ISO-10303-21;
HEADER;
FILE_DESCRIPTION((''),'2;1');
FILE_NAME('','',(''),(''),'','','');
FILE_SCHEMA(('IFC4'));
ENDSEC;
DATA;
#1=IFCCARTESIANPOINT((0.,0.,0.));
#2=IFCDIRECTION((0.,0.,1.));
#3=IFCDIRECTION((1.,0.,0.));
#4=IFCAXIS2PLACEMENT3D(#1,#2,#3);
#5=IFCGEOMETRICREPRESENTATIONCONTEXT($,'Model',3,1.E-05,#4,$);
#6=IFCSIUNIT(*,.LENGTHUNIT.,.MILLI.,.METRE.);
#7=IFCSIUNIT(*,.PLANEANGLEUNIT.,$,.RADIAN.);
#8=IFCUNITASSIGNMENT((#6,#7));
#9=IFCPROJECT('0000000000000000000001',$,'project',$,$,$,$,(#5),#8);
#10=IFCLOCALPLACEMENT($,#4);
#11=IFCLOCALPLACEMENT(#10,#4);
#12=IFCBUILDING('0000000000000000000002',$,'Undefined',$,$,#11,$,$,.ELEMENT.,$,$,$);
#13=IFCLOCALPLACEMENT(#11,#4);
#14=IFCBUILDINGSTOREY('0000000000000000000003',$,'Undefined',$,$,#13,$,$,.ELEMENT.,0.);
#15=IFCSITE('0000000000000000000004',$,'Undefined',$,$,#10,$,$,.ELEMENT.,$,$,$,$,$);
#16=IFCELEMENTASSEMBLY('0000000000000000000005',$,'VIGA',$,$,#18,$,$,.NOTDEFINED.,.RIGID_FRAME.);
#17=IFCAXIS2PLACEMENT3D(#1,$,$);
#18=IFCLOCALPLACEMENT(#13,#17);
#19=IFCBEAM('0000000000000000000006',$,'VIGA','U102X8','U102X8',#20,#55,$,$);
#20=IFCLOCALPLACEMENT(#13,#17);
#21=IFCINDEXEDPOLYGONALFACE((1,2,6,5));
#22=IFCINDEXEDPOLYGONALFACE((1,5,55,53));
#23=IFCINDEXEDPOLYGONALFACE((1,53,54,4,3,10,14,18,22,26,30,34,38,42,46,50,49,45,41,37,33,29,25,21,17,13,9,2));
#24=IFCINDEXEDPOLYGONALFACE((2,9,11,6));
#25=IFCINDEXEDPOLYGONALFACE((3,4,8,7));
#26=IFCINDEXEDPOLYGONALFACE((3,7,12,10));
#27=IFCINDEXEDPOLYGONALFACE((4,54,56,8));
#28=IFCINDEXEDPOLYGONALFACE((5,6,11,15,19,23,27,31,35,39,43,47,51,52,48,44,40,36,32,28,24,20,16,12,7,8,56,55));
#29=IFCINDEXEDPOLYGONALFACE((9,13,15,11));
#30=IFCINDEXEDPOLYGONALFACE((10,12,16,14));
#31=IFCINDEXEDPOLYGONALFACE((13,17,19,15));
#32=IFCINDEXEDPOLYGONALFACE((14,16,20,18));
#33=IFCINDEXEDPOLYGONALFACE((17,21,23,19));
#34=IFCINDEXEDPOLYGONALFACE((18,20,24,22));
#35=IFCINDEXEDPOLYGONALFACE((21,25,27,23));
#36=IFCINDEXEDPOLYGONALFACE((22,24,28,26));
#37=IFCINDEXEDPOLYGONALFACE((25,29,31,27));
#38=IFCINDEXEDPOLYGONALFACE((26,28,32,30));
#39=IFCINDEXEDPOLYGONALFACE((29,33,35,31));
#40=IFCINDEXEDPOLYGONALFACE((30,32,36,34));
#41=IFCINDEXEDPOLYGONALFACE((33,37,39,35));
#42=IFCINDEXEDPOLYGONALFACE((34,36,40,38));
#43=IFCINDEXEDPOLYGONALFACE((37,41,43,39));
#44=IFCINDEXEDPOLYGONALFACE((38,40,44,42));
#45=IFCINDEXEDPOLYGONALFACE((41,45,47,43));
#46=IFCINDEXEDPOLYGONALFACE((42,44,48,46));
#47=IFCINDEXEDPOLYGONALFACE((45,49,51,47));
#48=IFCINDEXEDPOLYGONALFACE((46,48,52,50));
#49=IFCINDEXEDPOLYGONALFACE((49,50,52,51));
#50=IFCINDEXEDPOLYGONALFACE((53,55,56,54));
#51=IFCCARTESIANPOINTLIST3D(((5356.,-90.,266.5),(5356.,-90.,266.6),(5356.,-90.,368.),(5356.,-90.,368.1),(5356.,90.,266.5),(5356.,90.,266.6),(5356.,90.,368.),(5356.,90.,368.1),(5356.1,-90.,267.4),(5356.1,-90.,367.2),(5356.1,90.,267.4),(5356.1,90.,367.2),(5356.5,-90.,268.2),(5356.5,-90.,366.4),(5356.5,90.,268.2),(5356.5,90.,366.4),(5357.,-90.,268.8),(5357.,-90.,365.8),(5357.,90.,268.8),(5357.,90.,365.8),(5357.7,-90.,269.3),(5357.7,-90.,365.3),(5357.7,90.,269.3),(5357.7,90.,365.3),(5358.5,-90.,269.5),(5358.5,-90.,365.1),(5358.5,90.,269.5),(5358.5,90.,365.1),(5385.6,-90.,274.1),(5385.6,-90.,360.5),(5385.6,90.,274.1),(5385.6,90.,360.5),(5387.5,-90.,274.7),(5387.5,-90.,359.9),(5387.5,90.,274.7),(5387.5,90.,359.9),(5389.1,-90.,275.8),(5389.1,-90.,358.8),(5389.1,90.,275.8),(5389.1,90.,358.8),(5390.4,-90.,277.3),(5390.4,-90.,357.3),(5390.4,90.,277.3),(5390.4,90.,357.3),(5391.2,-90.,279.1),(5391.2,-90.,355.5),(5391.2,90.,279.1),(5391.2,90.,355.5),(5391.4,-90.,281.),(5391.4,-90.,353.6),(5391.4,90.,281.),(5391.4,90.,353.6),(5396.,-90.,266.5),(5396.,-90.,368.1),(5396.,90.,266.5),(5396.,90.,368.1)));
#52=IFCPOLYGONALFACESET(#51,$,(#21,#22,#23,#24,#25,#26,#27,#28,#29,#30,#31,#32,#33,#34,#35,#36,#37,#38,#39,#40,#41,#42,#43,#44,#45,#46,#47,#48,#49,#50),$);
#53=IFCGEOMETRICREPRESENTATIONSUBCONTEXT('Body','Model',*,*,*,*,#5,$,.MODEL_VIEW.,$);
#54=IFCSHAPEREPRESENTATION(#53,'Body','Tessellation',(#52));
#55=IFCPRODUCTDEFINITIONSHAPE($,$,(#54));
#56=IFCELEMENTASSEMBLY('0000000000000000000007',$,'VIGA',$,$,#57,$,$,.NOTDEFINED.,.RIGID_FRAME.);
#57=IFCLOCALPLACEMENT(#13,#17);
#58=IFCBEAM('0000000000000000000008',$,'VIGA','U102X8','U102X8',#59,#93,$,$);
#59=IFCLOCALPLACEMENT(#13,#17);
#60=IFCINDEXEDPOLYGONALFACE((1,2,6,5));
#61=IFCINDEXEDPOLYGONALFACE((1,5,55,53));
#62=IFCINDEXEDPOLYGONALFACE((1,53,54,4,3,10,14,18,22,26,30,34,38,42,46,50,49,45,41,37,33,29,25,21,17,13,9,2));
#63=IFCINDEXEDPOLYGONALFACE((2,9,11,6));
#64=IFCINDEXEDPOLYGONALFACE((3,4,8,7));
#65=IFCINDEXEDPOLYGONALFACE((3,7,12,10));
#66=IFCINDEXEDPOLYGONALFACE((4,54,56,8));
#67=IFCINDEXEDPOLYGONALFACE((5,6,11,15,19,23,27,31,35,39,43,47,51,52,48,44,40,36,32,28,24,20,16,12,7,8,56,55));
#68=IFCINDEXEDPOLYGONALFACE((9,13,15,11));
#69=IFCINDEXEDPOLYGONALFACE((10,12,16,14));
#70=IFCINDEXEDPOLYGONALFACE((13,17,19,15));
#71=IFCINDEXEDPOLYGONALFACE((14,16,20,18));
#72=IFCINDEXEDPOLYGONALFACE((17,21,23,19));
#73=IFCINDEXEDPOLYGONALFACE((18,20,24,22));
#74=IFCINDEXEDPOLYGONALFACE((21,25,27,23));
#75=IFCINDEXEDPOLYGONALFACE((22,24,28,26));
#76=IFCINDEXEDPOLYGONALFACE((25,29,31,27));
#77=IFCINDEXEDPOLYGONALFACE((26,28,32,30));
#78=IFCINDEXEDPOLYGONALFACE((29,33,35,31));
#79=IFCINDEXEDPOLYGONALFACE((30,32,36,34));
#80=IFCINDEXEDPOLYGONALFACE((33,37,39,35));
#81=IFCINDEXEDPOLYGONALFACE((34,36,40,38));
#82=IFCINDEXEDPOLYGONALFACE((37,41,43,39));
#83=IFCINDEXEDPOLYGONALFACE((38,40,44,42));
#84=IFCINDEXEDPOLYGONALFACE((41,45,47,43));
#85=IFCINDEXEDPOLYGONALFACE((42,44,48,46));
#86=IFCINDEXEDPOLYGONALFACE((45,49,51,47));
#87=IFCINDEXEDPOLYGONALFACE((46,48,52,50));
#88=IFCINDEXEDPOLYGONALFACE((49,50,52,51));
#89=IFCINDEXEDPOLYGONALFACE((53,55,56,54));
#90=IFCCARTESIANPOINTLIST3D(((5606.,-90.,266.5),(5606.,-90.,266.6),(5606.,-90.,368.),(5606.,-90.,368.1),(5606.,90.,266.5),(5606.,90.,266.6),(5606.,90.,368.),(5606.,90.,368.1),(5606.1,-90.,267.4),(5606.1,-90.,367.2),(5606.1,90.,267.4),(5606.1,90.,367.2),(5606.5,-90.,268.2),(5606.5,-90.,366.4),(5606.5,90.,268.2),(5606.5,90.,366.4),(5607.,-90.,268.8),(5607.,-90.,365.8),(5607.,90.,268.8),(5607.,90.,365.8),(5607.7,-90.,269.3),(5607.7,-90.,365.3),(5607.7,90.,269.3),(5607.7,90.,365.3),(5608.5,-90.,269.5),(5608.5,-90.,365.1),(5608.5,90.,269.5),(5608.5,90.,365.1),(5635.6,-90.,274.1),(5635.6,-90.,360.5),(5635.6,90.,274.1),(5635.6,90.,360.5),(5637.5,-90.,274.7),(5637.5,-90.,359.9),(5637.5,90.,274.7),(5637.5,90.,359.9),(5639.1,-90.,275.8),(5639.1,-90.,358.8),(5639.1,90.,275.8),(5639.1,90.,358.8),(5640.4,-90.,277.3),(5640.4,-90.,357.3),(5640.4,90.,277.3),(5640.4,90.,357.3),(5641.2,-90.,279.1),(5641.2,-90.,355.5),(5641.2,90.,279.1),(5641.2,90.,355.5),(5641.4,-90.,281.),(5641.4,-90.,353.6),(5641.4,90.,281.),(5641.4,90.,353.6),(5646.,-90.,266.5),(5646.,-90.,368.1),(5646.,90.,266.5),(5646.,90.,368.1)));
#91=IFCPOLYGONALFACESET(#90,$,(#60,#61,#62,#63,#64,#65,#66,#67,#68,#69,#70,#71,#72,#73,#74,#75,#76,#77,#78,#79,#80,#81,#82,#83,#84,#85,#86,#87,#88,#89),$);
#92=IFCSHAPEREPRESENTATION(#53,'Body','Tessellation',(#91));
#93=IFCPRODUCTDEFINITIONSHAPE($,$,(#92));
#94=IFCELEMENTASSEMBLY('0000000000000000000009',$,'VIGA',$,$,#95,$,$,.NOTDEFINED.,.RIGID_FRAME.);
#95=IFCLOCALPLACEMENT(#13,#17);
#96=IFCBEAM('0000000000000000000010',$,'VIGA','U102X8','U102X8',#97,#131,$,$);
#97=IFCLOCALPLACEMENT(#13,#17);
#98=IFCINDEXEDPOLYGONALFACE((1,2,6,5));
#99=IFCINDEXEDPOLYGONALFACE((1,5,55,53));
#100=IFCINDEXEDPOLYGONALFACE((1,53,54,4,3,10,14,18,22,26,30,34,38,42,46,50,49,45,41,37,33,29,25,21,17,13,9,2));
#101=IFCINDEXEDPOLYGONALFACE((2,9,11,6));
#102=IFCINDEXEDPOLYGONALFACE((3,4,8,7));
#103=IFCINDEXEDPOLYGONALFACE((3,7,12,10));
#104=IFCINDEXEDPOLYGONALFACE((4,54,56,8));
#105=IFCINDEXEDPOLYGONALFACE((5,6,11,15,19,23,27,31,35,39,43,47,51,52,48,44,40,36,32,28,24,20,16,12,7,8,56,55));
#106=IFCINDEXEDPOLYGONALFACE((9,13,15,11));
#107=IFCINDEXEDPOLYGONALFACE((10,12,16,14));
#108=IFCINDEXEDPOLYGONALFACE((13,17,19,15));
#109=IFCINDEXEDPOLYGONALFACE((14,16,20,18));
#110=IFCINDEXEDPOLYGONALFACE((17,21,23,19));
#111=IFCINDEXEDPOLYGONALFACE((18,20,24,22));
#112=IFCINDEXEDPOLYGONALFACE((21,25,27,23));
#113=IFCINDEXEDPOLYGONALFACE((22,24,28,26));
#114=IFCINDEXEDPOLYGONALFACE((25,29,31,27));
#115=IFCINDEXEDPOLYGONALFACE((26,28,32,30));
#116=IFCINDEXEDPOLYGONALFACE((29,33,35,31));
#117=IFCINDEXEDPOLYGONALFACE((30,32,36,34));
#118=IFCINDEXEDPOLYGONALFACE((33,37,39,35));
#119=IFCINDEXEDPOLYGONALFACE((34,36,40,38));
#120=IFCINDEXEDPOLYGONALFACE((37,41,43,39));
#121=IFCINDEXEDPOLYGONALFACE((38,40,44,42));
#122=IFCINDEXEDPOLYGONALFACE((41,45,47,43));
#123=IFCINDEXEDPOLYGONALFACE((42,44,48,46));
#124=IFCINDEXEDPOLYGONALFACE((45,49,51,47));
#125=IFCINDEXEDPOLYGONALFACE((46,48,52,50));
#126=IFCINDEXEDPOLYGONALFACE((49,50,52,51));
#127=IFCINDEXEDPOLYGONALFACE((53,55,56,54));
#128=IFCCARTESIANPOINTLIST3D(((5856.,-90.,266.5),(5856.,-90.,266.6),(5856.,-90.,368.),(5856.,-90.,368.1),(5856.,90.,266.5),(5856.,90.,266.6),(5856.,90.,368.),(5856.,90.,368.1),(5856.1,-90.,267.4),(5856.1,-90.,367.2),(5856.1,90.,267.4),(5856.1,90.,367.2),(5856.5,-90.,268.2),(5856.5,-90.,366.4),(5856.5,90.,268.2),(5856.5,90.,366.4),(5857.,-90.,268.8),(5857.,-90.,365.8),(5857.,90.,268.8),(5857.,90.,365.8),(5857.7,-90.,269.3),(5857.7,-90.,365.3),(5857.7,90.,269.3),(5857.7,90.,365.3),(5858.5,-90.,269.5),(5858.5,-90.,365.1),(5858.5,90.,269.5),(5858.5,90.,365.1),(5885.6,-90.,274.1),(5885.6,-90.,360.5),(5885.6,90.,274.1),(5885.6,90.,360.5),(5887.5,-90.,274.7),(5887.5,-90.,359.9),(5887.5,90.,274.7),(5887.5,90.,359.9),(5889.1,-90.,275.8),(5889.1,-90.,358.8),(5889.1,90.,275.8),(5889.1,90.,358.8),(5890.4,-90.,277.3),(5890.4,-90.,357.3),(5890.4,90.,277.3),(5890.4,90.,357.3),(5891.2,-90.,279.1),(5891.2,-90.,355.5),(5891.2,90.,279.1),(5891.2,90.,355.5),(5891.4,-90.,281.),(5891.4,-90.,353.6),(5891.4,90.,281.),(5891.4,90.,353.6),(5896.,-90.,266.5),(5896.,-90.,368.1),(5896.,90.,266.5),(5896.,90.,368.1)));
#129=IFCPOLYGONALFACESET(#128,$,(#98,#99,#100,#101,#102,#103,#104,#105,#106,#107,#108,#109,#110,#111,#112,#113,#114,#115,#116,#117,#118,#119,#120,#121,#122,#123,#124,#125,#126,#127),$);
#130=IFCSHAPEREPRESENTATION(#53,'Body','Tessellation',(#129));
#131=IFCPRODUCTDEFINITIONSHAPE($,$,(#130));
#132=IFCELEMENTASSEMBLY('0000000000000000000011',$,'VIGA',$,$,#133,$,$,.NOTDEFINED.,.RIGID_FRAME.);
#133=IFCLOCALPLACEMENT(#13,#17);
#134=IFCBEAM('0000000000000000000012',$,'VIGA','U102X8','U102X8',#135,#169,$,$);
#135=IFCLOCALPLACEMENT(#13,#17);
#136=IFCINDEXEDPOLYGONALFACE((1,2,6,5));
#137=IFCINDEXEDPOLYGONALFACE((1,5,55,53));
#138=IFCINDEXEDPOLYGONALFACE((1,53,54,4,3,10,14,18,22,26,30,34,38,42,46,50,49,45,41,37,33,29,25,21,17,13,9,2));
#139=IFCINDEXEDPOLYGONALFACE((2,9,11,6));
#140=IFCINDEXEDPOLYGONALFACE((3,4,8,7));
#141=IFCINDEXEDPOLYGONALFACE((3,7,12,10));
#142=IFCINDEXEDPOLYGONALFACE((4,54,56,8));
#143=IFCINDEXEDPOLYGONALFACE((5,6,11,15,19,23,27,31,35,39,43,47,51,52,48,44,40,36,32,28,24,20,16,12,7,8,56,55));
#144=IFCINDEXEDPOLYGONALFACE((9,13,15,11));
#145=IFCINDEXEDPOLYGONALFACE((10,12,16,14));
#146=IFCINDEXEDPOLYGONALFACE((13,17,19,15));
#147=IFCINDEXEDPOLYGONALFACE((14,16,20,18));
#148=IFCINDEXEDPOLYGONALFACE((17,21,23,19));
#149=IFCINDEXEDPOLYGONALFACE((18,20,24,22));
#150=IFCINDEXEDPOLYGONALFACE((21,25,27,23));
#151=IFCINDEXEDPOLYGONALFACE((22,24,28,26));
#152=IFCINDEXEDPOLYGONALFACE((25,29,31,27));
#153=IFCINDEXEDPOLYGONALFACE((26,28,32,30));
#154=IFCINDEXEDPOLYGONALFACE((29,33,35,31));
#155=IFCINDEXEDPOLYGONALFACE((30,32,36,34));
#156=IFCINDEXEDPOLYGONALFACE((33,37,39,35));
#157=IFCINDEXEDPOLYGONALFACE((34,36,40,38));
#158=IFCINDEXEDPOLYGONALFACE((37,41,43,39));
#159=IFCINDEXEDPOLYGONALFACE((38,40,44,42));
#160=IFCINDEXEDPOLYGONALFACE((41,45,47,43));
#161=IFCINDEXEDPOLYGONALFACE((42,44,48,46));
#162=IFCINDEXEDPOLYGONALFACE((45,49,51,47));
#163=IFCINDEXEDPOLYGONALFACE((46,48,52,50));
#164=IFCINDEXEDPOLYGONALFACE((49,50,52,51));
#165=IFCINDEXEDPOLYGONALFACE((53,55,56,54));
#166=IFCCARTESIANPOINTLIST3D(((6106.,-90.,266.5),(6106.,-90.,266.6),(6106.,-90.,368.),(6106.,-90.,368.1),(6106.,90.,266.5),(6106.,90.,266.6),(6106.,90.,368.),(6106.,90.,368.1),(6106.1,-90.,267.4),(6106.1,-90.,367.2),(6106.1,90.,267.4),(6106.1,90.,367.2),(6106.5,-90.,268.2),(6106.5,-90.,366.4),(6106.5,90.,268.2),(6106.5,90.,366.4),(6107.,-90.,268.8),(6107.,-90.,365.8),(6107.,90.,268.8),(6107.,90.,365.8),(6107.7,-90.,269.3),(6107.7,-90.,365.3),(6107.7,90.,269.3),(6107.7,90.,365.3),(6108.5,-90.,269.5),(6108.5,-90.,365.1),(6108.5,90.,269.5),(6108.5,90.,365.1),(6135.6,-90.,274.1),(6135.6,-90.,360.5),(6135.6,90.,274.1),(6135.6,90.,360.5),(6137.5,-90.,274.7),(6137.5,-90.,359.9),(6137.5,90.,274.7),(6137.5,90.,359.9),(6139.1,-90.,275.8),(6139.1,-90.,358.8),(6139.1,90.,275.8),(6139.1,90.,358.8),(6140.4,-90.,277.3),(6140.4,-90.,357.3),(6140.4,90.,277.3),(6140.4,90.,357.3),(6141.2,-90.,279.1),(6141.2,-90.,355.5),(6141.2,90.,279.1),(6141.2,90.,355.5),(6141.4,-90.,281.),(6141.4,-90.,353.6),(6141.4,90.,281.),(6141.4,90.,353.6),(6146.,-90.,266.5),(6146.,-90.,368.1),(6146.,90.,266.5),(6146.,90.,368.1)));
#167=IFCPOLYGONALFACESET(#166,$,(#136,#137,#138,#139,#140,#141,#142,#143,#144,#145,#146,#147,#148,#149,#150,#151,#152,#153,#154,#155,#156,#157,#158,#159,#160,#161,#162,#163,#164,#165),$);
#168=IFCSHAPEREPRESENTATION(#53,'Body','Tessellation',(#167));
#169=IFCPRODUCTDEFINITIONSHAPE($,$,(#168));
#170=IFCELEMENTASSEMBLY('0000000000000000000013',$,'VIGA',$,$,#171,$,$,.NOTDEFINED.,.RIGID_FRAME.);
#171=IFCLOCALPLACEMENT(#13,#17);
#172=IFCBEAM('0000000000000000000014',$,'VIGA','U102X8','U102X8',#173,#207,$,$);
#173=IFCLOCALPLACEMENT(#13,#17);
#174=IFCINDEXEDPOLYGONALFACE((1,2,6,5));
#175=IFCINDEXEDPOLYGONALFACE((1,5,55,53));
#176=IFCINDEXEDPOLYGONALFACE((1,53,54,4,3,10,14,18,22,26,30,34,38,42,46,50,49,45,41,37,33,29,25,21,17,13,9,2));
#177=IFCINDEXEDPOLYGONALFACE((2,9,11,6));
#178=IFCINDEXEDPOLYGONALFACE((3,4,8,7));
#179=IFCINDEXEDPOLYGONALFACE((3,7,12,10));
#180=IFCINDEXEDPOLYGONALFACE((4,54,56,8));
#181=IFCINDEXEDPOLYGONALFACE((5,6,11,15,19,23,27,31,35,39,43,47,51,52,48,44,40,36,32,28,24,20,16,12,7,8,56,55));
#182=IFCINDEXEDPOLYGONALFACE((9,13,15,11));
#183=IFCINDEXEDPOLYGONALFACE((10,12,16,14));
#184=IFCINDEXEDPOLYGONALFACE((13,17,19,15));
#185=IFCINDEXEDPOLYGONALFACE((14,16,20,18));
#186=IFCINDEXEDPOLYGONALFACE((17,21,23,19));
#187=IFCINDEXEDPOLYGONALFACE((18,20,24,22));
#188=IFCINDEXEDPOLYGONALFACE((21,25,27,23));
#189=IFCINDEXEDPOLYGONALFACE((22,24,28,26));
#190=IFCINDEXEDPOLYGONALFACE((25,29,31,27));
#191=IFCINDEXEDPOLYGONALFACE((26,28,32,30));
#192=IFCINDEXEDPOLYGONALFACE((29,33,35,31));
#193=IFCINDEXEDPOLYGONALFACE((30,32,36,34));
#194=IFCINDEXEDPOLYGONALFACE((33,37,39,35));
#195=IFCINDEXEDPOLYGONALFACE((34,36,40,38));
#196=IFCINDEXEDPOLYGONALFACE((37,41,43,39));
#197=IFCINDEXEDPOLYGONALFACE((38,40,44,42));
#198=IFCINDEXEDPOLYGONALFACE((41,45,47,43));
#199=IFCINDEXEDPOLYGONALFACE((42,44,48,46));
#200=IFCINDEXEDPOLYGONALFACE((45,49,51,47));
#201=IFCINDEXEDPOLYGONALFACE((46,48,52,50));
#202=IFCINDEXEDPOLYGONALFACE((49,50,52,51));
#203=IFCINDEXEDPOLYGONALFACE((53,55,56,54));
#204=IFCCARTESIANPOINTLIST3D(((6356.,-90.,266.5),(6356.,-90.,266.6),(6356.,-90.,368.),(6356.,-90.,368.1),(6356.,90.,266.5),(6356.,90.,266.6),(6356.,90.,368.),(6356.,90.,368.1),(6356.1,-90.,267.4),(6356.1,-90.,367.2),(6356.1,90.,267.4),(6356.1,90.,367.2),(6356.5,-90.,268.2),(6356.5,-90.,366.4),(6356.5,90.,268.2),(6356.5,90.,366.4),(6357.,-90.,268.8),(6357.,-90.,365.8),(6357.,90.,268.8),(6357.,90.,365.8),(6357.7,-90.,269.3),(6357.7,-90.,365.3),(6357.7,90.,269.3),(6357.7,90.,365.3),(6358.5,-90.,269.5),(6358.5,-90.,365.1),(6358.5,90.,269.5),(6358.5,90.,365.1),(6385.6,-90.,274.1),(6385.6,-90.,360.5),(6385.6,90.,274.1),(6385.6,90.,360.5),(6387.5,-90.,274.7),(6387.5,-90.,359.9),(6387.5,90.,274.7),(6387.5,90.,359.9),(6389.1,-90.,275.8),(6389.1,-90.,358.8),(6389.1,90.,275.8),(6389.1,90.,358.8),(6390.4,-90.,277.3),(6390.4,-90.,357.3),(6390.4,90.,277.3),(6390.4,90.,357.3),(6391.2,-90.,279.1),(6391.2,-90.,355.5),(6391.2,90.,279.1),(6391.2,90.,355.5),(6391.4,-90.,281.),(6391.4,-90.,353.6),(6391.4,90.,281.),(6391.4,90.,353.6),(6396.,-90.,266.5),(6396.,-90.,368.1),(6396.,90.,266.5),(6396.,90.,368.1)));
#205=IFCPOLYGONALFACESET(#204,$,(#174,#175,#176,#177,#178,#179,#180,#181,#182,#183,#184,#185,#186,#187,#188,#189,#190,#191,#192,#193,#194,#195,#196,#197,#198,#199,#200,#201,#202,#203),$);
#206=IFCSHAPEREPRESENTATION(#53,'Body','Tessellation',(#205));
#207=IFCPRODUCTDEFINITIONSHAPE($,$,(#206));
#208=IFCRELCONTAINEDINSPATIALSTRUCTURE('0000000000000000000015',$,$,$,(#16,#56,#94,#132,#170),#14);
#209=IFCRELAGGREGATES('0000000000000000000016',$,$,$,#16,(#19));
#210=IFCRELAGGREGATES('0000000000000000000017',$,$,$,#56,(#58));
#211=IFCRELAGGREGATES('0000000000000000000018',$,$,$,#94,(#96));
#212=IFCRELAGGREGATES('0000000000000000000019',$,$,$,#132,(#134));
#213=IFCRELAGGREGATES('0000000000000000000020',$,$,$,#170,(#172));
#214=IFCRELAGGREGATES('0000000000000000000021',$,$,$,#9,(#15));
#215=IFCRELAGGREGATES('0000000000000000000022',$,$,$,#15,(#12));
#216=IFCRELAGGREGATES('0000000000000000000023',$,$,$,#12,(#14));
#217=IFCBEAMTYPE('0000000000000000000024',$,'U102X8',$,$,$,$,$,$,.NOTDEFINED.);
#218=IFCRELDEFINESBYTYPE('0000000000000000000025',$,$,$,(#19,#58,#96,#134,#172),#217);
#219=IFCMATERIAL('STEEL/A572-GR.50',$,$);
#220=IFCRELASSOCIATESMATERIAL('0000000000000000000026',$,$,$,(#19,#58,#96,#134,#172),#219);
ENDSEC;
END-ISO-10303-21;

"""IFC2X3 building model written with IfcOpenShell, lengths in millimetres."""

from ifc_helpers import new_model, si_unit, frame, origin_with_axes, origin_2d_with_axis, place, context, subcontext, project, spatial, u_section, extrude, material, type_object, element, aggregate, save


model = new_model("IFC2X3")

# Units and contexts
model_context = context("Model", 3, precision=1e-05, world=origin_with_axes())
body_context = subcontext(model_context, "Body", "Model", "MODEL_VIEW")
ifc_project = project(units=[si_unit("LENGTHUNIT", "METRE", prefix="MILLI"), si_unit("PLANEANGLEUNIT", "RADIAN")], contexts=[model_context])

# Site, building, storey
site_placement = place(None, origin_with_axes())
site = spatial("IfcSite", under=ifc_project, at=site_placement, Name="Undefined", CompositionType="ELEMENT")
building_placement = place(site_placement, origin_with_axes())
building = spatial("IfcBuilding", under=site, at=building_placement, Name="Undefined", CompositionType="ELEMENT")
storey_placement = place(building_placement, origin_with_axes())
storey = spatial("IfcBuildingStorey", under=building, at=storey_placement, Name="Undefined", CompositionType="ELEMENT", Elevation=0.0)

# Element assemblies, beams
ifc_material_1 = material(Name="STEEL/A572-GR.50")
beam_type = type_object("IfcBeamType", Name="U102X8", PredefinedType="NOTDEFINED")
assembly_1_placement = place(storey_placement, origin_with_axes())
assembly_1 = element("IfcElementAssembly", 1, at=assembly_1_placement, inside=storey, Name="VIGA", AssemblyPlace="NOTDEFINED", PredefinedType="RIGID_FRAME")
beam_1_placement = place(assembly_1_placement, frame((5376.0, 90.0, 317.3), z_axis=(0.0, 0.0, 1.0), x_axis=(0.0, -1.0, 0.0)))
beam_1 = element("IfcBeam", 2, at=beam_1_placement, type_object=beam_type, material=ifc_material_1, Name="VIGA", Description="U102X8", ObjectType="U102X8", context=body_context, shape_type="SweptSolid", body=[
    extrude(u_section(Depth=101.6, FlangeWidth=40.0, WebThickness=4.6, FlangeThickness=6.0, FilletRadius=7.0, EdgeRadius=3.0, FlangeSlope=0.16839, at=origin_2d_with_axis()), frame((180.0, 0.0, 0.0), z_axis=(-1.0, 0.0, 0.0), x_axis=(0.0, -1.0, 0.0)), (0.0, 0.0, 1.0), 180.0),
])
aggregate(assembly_1, [beam_1])
assembly_2_placement = place(storey_placement, origin_with_axes())
assembly_2 = element("IfcElementAssembly", 3, at=assembly_2_placement, inside=storey, Name="VIGA", AssemblyPlace="NOTDEFINED", PredefinedType="RIGID_FRAME")
beam_2_placement = place(assembly_2_placement, frame((5626.0, 90.0, 317.3), z_axis=(0.0, 0.0, 1.0), x_axis=(0.0, -1.0, 0.0)))
beam_2 = element("IfcBeam", 4, at=beam_2_placement, type_object=beam_type, material=ifc_material_1, Name="VIGA", Description="U102X8", ObjectType="U102X8", context=body_context, shape_type="SweptSolid", body=[
    extrude(u_section(Depth=101.6, FlangeWidth=40.0, WebThickness=4.6, FlangeThickness=6.0, FilletRadius=7.0, EdgeRadius=3.0, FlangeSlope=0.16839, at=origin_2d_with_axis()), frame((180.0, 0.0, 0.0), z_axis=(-1.0, 0.0, 0.0), x_axis=(0.0, -1.0, 0.0)), (0.0, 0.0, 1.0), 180.0),
])
aggregate(assembly_2, [beam_2])
assembly_3_placement = place(storey_placement, origin_with_axes())
assembly_3 = element("IfcElementAssembly", 5, at=assembly_3_placement, inside=storey, Name="VIGA", AssemblyPlace="NOTDEFINED", PredefinedType="RIGID_FRAME")
beam_3_placement = place(assembly_3_placement, frame((5876.0, 90.0, 317.3), z_axis=(0.0, 0.0, 1.0), x_axis=(0.0, -1.0, 0.0)))
beam_3 = element("IfcBeam", 6, at=beam_3_placement, type_object=beam_type, material=ifc_material_1, Name="VIGA", Description="U102X8", ObjectType="U102X8", context=body_context, shape_type="SweptSolid", body=[
    extrude(u_section(Depth=101.6, FlangeWidth=40.0, WebThickness=4.6, FlangeThickness=6.0, FilletRadius=7.0, EdgeRadius=3.0, FlangeSlope=0.16839, at=origin_2d_with_axis()), frame((180.0, 0.0, 0.0), z_axis=(-1.0, 0.0, 0.0), x_axis=(0.0, -1.0, 0.0)), (0.0, 0.0, 1.0), 180.0),
])
aggregate(assembly_3, [beam_3])
assembly_4_placement = place(storey_placement, origin_with_axes())
assembly_4 = element("IfcElementAssembly", 7, at=assembly_4_placement, inside=storey, Name="VIGA", AssemblyPlace="NOTDEFINED", PredefinedType="RIGID_FRAME")
beam_4_placement = place(assembly_4_placement, frame((6126.0, 90.0, 317.3), z_axis=(0.0, 0.0, 1.0), x_axis=(0.0, -1.0, 0.0)))
beam_4 = element("IfcBeam", 8, at=beam_4_placement, type_object=beam_type, material=ifc_material_1, Name="VIGA", Description="U102X8", ObjectType="U102X8", context=body_context, shape_type="SweptSolid", body=[
    extrude(u_section(Depth=101.6, FlangeWidth=40.0, WebThickness=4.6, FlangeThickness=6.0, FilletRadius=7.0, EdgeRadius=3.0, FlangeSlope=0.16839, at=origin_2d_with_axis()), frame((180.0, 0.0, 0.0), z_axis=(-1.0, 0.0, 0.0), x_axis=(0.0, -1.0, 0.0)), (0.0, 0.0, 1.0), 180.0),
])
aggregate(assembly_4, [beam_4])
assembly_5_placement = place(storey_placement, origin_with_axes())
assembly_5 = element("IfcElementAssembly", 9, at=assembly_5_placement, inside=storey, Name="VIGA", AssemblyPlace="NOTDEFINED", PredefinedType="RIGID_FRAME")
beam_5_placement = place(assembly_5_placement, frame((6376.0, 90.0, 317.3), z_axis=(0.0, 0.0, 1.0), x_axis=(0.0, -1.0, 0.0)))
beam_5 = element("IfcBeam", 10, at=beam_5_placement, type_object=beam_type, material=ifc_material_1, Name="VIGA", Description="U102X8", ObjectType="U102X8", context=body_context, shape_type="SweptSolid", body=[
    extrude(u_section(Depth=101.6, FlangeWidth=40.0, WebThickness=4.6, FlangeThickness=6.0, FilletRadius=7.0, EdgeRadius=3.0, FlangeSlope=0.16839, at=origin_2d_with_axis()), frame((180.0, 0.0, 0.0), z_axis=(-1.0, 0.0, 0.0), x_axis=(0.0, -1.0, 0.0)), (0.0, 0.0, 1.0), 180.0),
])
aggregate(assembly_5, [beam_5])

save(model, "model.ifc")
